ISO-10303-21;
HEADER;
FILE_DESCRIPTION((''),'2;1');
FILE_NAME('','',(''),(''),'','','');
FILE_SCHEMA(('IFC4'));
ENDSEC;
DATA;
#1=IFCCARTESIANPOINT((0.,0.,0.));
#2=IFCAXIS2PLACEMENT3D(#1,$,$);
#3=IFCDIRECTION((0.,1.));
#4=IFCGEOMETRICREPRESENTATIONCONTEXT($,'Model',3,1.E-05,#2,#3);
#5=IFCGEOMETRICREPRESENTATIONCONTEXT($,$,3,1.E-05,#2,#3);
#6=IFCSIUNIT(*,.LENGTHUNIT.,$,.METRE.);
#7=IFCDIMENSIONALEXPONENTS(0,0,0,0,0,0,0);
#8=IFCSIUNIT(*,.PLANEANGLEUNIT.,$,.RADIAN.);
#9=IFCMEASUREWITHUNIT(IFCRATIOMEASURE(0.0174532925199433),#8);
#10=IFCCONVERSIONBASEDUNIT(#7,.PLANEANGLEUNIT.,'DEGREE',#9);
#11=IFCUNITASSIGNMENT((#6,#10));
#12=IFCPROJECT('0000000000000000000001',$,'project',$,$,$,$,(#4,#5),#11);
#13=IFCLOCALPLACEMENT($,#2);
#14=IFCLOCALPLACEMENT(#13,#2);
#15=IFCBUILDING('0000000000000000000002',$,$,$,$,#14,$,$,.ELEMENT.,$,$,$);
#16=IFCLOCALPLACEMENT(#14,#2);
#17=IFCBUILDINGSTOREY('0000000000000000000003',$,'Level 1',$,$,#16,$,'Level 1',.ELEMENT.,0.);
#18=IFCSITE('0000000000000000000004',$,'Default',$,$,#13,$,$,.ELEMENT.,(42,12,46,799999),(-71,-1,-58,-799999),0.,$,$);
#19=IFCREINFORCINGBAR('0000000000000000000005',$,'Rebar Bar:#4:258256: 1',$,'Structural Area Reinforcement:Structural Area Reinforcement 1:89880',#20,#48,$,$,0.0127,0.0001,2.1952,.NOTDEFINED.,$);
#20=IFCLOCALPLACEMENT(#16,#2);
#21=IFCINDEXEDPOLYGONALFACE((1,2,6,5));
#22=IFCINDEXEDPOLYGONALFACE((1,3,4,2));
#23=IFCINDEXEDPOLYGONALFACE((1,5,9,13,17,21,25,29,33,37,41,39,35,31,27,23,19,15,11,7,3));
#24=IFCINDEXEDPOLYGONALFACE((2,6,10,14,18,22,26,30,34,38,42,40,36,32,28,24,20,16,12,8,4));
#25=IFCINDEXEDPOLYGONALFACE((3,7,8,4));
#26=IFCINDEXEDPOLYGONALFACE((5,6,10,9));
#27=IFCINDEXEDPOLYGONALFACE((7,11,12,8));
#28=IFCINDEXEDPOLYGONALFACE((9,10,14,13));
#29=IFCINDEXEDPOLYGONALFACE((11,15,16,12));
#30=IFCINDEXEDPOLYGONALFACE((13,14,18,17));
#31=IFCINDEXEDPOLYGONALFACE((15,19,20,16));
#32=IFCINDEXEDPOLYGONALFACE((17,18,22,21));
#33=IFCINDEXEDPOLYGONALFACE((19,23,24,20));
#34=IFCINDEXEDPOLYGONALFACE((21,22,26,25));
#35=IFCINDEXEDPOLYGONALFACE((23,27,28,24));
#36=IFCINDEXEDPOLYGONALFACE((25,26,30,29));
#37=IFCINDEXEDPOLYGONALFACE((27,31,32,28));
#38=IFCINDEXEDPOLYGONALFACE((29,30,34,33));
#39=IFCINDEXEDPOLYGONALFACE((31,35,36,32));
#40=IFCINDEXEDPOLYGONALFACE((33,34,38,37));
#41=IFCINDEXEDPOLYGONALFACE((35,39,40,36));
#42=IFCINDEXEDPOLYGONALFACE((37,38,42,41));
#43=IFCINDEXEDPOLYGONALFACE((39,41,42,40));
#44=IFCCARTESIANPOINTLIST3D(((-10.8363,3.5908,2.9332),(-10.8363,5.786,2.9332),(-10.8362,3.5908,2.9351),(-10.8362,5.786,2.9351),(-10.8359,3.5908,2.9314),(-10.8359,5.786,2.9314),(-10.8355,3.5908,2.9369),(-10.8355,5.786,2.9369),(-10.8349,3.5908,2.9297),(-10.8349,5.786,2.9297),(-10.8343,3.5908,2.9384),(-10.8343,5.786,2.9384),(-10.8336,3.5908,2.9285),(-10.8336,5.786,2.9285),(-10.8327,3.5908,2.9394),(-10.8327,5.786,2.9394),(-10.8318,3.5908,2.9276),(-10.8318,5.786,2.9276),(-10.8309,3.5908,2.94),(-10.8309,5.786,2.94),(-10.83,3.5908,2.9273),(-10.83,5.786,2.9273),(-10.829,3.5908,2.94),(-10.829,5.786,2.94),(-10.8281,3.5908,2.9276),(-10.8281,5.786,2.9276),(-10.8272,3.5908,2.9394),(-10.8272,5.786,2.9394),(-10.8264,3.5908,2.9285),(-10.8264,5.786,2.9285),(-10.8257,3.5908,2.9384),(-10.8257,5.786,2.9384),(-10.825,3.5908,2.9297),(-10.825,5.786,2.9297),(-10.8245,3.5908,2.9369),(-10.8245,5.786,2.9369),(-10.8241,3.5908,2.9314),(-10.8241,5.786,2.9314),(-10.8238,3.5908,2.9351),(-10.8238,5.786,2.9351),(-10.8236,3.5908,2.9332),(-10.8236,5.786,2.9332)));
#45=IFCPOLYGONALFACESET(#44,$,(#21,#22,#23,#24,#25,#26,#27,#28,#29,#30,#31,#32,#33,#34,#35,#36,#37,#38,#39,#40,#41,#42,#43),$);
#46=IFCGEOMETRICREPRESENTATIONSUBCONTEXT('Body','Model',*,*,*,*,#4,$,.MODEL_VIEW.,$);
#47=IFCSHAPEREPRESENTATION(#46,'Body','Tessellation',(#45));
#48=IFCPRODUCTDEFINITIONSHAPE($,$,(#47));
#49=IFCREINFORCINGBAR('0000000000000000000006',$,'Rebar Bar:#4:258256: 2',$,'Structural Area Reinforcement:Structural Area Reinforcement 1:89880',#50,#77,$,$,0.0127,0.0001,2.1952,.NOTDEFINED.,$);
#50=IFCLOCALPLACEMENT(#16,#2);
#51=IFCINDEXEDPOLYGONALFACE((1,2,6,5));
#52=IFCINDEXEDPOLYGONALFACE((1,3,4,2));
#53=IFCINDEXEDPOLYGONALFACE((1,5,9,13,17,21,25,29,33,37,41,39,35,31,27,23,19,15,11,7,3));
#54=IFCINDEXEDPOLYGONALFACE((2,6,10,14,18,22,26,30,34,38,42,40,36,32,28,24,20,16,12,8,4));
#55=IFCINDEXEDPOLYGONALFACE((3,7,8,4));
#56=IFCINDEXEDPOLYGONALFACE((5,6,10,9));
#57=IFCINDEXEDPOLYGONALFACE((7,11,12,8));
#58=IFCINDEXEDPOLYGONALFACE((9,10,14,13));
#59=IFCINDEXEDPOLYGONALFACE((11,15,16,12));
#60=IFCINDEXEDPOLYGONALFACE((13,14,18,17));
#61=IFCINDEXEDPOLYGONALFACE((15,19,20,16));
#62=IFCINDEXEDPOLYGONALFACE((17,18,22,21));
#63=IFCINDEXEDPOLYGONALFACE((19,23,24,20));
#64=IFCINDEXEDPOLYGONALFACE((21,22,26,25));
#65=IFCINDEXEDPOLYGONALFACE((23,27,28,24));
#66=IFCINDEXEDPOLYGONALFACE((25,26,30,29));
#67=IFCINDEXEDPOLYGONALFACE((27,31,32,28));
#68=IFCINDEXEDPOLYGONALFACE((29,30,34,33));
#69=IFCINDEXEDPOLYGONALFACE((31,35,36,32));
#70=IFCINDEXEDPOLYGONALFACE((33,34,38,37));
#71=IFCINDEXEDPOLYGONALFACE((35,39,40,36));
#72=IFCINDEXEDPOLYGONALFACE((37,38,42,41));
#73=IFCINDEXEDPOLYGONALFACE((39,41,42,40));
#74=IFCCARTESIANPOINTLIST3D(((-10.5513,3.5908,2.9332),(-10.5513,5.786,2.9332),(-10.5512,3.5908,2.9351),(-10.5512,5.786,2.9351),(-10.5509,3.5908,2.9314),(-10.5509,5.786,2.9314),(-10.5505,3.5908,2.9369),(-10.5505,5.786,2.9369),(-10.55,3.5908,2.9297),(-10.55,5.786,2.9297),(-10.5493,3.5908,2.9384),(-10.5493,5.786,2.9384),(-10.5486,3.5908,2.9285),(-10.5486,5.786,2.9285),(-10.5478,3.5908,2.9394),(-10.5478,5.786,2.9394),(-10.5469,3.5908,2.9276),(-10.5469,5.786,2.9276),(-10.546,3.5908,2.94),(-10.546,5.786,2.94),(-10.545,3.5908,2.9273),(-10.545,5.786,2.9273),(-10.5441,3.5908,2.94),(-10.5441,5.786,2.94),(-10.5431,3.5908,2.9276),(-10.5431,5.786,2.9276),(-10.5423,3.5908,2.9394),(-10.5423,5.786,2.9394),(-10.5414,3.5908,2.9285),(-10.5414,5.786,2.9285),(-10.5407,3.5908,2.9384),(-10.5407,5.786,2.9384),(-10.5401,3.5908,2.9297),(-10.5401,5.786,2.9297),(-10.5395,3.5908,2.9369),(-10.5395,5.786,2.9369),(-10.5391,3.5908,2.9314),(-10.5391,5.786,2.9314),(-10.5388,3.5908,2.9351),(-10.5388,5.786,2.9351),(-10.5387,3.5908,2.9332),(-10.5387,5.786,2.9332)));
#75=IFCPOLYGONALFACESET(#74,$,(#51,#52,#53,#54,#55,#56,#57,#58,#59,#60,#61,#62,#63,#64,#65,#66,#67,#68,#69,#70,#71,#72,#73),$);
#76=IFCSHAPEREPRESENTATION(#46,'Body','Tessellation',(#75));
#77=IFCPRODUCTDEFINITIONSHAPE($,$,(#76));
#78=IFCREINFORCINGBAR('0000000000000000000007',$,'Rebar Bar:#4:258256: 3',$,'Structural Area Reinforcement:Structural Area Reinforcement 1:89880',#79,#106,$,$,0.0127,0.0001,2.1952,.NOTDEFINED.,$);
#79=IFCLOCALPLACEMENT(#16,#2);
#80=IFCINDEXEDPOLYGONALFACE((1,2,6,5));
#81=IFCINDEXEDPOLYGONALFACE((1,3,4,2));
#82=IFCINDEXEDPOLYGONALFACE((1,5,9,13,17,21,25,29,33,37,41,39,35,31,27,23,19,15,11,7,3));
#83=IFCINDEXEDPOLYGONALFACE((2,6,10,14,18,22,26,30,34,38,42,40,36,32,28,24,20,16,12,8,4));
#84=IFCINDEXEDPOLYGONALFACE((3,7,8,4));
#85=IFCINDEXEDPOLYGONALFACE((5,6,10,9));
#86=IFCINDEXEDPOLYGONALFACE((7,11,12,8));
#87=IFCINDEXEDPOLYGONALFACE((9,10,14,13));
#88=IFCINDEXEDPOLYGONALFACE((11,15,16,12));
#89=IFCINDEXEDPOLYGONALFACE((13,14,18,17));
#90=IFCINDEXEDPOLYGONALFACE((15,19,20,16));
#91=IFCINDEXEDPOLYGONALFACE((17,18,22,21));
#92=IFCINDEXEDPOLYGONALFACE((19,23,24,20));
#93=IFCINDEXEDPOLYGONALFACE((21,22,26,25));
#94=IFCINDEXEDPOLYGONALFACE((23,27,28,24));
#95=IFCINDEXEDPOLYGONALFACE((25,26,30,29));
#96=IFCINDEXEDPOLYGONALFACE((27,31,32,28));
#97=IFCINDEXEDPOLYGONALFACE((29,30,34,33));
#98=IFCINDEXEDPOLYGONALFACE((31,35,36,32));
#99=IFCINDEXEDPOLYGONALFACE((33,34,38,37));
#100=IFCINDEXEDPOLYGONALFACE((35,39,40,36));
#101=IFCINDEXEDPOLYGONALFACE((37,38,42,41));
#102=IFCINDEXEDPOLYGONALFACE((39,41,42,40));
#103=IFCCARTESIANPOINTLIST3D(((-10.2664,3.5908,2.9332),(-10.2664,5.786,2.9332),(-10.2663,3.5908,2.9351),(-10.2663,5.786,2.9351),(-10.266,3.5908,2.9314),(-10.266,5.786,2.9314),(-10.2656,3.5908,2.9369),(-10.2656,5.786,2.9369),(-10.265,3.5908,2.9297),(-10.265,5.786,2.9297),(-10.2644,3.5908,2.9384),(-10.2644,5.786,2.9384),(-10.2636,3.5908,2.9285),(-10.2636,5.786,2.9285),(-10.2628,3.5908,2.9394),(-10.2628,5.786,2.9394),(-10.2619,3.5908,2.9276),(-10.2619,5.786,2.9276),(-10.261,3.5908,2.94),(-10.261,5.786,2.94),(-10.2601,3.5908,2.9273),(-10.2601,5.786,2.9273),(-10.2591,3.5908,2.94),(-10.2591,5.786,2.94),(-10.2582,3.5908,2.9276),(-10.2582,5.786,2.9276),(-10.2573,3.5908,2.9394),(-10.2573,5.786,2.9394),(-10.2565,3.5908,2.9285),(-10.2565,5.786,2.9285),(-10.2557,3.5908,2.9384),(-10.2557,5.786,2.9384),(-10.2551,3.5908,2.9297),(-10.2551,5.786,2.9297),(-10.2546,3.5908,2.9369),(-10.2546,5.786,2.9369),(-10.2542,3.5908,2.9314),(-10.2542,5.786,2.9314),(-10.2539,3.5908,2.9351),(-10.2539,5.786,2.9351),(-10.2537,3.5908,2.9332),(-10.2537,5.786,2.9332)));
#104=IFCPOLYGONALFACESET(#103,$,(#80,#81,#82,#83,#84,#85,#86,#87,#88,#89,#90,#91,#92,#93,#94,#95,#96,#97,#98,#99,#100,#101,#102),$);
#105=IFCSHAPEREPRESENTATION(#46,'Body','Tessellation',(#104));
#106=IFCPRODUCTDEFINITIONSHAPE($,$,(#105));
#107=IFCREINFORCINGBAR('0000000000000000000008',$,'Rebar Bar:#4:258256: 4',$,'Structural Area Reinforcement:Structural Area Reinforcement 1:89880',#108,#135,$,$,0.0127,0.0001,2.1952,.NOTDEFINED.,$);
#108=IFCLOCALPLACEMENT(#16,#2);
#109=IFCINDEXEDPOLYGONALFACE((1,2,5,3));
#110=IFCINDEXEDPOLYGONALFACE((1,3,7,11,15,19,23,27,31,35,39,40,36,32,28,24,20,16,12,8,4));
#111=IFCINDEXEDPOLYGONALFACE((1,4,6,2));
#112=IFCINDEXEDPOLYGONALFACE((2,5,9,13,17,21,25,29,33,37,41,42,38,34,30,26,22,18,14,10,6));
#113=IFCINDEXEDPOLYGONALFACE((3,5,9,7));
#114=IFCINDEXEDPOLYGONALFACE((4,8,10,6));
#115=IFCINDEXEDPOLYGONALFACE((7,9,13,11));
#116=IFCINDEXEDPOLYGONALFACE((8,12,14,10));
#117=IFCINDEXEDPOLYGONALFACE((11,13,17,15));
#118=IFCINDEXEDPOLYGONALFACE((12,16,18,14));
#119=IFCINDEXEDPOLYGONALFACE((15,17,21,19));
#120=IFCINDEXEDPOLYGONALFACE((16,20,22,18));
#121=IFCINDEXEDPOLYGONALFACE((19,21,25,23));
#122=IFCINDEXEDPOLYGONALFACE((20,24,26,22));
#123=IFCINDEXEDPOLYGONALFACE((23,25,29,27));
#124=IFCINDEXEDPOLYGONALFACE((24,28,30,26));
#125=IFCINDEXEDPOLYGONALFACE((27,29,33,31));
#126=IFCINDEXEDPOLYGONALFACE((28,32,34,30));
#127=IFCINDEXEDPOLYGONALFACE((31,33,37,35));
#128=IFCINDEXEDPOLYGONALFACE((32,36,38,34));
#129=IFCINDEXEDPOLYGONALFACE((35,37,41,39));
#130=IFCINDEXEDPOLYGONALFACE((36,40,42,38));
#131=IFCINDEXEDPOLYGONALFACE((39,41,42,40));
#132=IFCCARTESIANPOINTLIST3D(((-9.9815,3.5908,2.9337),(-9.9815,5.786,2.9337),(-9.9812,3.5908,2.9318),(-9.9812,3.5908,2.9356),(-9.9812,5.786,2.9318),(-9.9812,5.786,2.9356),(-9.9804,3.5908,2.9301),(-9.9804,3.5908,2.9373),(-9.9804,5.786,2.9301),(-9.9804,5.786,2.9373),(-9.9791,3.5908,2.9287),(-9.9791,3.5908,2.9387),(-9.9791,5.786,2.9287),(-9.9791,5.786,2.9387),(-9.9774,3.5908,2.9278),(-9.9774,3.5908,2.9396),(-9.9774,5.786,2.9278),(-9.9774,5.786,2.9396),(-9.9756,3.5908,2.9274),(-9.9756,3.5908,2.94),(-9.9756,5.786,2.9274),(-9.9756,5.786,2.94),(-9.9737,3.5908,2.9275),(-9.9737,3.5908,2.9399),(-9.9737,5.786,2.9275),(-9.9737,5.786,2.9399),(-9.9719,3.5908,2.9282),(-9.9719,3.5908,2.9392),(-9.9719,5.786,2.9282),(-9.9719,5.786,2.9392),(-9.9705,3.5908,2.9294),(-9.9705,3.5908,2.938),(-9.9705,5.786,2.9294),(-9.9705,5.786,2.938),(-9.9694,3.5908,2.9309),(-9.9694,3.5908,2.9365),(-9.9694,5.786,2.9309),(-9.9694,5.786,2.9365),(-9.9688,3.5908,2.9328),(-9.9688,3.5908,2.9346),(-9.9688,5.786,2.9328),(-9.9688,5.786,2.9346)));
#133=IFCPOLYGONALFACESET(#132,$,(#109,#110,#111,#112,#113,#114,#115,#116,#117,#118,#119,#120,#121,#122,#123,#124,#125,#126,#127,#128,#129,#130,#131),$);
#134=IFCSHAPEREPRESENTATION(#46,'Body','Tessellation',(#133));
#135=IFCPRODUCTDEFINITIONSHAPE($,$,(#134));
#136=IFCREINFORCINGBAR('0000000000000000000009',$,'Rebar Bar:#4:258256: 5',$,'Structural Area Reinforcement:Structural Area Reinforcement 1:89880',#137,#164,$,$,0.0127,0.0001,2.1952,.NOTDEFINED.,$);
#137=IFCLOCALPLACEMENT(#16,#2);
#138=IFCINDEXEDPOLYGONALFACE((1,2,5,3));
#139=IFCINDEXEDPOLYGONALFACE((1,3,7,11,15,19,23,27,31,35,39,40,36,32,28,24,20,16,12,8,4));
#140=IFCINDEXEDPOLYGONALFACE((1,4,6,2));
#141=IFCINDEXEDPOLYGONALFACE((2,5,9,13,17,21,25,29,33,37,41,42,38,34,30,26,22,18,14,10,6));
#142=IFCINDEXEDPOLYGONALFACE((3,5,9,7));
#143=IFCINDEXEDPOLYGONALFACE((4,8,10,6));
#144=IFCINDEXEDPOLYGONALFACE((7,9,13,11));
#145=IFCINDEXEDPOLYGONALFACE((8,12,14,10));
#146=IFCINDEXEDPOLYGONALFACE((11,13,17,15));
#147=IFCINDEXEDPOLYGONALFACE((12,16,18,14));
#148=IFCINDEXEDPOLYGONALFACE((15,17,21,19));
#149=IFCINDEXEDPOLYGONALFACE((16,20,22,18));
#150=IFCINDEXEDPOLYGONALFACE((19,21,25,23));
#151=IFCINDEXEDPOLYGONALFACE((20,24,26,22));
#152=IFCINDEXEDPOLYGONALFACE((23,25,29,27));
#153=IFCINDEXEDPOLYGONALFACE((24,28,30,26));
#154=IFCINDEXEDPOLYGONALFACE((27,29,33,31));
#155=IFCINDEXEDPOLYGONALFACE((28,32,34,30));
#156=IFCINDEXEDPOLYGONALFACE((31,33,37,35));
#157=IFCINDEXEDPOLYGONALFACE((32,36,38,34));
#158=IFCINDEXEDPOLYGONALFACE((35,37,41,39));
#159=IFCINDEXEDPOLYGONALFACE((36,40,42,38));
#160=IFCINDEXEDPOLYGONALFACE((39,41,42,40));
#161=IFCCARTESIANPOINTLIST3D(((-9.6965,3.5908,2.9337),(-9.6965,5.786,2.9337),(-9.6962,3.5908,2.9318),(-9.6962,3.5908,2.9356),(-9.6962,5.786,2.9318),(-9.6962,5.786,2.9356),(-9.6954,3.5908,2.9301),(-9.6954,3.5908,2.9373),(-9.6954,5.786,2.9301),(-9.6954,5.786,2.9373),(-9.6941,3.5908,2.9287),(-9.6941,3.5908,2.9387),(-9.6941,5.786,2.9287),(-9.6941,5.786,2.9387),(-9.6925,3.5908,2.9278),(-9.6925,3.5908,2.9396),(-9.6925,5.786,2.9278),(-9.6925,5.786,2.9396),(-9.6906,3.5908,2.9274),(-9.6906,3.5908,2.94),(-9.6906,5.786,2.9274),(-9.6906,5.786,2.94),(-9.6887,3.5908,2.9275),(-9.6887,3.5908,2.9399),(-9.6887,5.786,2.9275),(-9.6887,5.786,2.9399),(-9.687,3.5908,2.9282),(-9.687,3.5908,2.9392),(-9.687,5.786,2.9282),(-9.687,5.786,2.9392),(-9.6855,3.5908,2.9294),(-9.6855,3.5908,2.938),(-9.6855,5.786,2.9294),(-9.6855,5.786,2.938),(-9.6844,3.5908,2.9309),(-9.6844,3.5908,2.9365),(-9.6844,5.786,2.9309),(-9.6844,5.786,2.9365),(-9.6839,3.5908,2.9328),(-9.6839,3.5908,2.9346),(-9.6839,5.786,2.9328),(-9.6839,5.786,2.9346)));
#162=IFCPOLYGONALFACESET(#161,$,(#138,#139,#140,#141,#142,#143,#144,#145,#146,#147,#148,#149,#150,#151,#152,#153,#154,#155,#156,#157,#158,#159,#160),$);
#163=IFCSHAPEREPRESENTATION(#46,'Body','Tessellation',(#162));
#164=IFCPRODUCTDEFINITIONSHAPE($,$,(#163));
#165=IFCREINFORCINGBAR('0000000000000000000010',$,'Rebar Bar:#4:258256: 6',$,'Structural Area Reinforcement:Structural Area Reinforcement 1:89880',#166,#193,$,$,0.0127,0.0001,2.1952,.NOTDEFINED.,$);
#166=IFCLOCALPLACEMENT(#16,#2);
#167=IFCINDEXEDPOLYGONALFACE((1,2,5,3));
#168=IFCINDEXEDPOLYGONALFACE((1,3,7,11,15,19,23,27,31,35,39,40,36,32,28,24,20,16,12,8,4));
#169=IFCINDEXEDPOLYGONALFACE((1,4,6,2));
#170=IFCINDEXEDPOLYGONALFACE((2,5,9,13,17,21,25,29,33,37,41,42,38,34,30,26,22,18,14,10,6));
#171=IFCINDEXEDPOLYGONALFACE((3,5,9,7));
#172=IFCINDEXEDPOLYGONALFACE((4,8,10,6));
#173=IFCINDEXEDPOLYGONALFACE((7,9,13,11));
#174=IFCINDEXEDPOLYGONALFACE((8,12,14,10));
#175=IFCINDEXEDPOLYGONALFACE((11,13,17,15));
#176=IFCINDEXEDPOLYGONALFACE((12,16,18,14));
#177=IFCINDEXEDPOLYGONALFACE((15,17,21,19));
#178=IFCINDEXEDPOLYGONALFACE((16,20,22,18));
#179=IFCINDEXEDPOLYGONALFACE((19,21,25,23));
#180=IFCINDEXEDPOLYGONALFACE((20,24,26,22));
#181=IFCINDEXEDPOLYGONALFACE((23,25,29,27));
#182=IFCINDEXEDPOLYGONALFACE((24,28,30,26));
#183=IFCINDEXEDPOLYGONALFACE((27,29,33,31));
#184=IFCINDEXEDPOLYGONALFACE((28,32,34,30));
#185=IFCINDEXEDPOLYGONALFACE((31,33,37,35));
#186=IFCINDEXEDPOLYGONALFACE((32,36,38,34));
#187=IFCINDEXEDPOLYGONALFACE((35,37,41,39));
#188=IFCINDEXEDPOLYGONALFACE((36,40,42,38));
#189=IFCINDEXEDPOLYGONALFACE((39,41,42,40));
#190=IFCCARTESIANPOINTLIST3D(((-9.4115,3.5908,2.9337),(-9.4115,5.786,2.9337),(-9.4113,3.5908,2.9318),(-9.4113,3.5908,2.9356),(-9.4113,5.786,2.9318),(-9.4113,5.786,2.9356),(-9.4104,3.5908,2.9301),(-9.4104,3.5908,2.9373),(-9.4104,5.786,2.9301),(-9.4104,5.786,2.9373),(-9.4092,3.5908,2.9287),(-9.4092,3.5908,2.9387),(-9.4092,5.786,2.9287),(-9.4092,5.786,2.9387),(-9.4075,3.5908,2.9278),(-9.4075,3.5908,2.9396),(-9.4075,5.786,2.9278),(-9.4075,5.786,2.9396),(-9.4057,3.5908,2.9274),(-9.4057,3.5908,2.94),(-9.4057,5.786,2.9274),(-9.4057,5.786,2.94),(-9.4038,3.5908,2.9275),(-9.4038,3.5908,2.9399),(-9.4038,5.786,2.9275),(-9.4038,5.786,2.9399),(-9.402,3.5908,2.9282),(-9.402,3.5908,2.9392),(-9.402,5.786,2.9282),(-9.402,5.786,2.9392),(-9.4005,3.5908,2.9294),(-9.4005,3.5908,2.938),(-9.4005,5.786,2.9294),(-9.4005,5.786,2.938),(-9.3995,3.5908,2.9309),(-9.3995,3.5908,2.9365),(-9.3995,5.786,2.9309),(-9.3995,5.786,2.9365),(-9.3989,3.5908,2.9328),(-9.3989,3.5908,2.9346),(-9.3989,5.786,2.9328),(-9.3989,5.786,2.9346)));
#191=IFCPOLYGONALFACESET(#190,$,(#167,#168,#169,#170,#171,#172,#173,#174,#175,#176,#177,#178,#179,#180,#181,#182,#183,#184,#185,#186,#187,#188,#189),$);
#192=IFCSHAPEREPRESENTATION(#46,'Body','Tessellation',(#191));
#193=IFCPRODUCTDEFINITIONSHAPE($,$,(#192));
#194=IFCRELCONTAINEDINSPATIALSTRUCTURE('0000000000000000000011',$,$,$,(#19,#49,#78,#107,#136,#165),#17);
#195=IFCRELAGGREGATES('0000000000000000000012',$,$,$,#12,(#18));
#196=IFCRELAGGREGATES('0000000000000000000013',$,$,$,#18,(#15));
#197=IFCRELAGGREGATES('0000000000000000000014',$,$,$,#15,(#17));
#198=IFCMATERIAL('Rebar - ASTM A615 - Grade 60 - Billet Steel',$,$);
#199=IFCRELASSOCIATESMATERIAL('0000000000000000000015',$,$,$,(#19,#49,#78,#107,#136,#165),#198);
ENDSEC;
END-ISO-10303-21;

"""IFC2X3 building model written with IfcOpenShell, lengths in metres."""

from ifc_helpers import new_model, entity, si_unit, converted_unit, direction, origin, place, context, subcontext, project, spatial, material, element, save


model = new_model("IFC2X3")

# Units and contexts
model_context = context("Model", 3, precision=1e-05, world=origin(), true_north=direction((0.0, 1.0)))
context_of_model = context(None, 3, precision=1e-05, world=origin(), true_north=direction((0.0, 1.0)))
body_context = subcontext(model_context, "Body", "Model", "MODEL_VIEW")
ifc_project = project(units=[si_unit("LENGTHUNIT", "METRE"), converted_unit("PLANEANGLEUNIT", "DEGREE", entity("IfcRatioMeasure", 0.0174532925199433), si_unit("PLANEANGLEUNIT", "RADIAN"), dimensions=[0, 0, 0, 0, 0, 0, 0])], contexts=[model_context, context_of_model])

# Site, building, storey
site_placement = place(None, origin())
site = spatial("IfcSite", under=ifc_project, at=site_placement, Name="Default", CompositionType="ELEMENT", RefLatitude=(42, 12, 46, 799999), RefLongitude=(-71, -1, -58, -799999), RefElevation=0.0)
building_placement = place(site_placement, origin())
building = spatial("IfcBuilding", under=site, at=building_placement, CompositionType="ELEMENT")
storey_placement = place(building_placement, origin())
storey = spatial("IfcBuildingStorey", under=building, at=storey_placement, Name="Level 1", LongName="Level 1", CompositionType="ELEMENT", Elevation=0.0)

# Shared definitions
ifc_material_1 = material(Name="Rebar - ASTM A615 - Grade 60 - Billet Steel")

# Reinforcing bars
reinforcing_bar_1_placement = place(storey_placement, origin())
element("IfcReinforcingBar", 1, at=reinforcing_bar_1_placement, inside=storey, material=ifc_material_1, Name="Rebar Bar:#4:258256: 1", ObjectType="Structural Area Reinforcement:Structural Area Reinforcement 1:89880", BarLength=2.1952, BarRole="NOTDEFINED", CrossSectionArea=0.0001, NominalDiameter=0.0127, context=body_context, shape_type="AdvancedSweptSolid", body=[
    entity("IfcSweptDiskSolid", entity("IfcCompositeCurve", [entity("IfcCompositeCurveSegment", "CONTINUOUS", True, entity("IfcPolyline", [entity("IfcCartesianPoint", [-10.83, 5.786, 2.9337]), entity("IfcCartesianPoint", [-10.83, 3.5908, 2.9337])]))], False), 0.0063, None, 0.0, 1.0),
])
reinforcing_bar_2_placement = place(storey_placement, origin())
element("IfcReinforcingBar", 2, at=reinforcing_bar_2_placement, inside=storey, material=ifc_material_1, Name="Rebar Bar:#4:258256: 2", ObjectType="Structural Area Reinforcement:Structural Area Reinforcement 1:89880", BarLength=2.1952, BarRole="NOTDEFINED", CrossSectionArea=0.0001, NominalDiameter=0.0127, context=body_context, shape_type="AdvancedSweptSolid", body=[
    entity("IfcSweptDiskSolid", entity("IfcCompositeCurve", [entity("IfcCompositeCurveSegment", "CONTINUOUS", True, entity("IfcPolyline", [entity("IfcCartesianPoint", [-10.545, 5.786, 2.9337]), entity("IfcCartesianPoint", [-10.545, 3.5908, 2.9337])]))], False), 0.0063, None, 0.0, 1.0),
])
reinforcing_bar_3_placement = place(storey_placement, origin())
element("IfcReinforcingBar", 3, at=reinforcing_bar_3_placement, inside=storey, material=ifc_material_1, Name="Rebar Bar:#4:258256: 3", ObjectType="Structural Area Reinforcement:Structural Area Reinforcement 1:89880", BarLength=2.1952, BarRole="NOTDEFINED", CrossSectionArea=0.0001, NominalDiameter=0.0127, context=body_context, shape_type="AdvancedSweptSolid", body=[
    entity("IfcSweptDiskSolid", entity("IfcCompositeCurve", [entity("IfcCompositeCurveSegment", "CONTINUOUS", True, entity("IfcPolyline", [entity("IfcCartesianPoint", [-10.2601, 5.786, 2.9337]), entity("IfcCartesianPoint", [-10.2601, 3.5908, 2.9337])]))], False), 0.0063, None, 0.0, 1.0),
])
reinforcing_bar_4_placement = place(storey_placement, origin())
element("IfcReinforcingBar", 4, at=reinforcing_bar_4_placement, inside=storey, material=ifc_material_1, Name="Rebar Bar:#4:258256: 4", ObjectType="Structural Area Reinforcement:Structural Area Reinforcement 1:89880", BarLength=2.1952, BarRole="NOTDEFINED", CrossSectionArea=0.0001, NominalDiameter=0.0127, context=body_context, shape_type="AdvancedSweptSolid", body=[
    entity("IfcSweptDiskSolid", entity("IfcCompositeCurve", [entity("IfcCompositeCurveSegment", "CONTINUOUS", True, entity("IfcPolyline", [entity("IfcCartesianPoint", [-9.9751, 5.786, 2.9337]), entity("IfcCartesianPoint", [-9.9751, 3.5908, 2.9337])]))], False), 0.0063, None, 0.0, 1.0),
])
reinforcing_bar_5_placement = place(storey_placement, origin())
element("IfcReinforcingBar", 5, at=reinforcing_bar_5_placement, inside=storey, material=ifc_material_1, Name="Rebar Bar:#4:258256: 5", ObjectType="Structural Area Reinforcement:Structural Area Reinforcement 1:89880", BarLength=2.1952, BarRole="NOTDEFINED", CrossSectionArea=0.0001, NominalDiameter=0.0127, context=body_context, shape_type="AdvancedSweptSolid", body=[
    entity("IfcSweptDiskSolid", entity("IfcCompositeCurve", [entity("IfcCompositeCurveSegment", "CONTINUOUS", True, entity("IfcPolyline", [entity("IfcCartesianPoint", [-9.6901, 5.786, 2.9337]), entity("IfcCartesianPoint", [-9.6901, 3.5908, 2.9337])]))], False), 0.0063, None, 0.0, 1.0),
])
reinforcing_bar_6_placement = place(storey_placement, origin())
element("IfcReinforcingBar", 6, at=reinforcing_bar_6_placement, inside=storey, material=ifc_material_1, Name="Rebar Bar:#4:258256: 6", ObjectType="Structural Area Reinforcement:Structural Area Reinforcement 1:89880", BarLength=2.1952, BarRole="NOTDEFINED", CrossSectionArea=0.0001, NominalDiameter=0.0127, context=body_context, shape_type="AdvancedSweptSolid", body=[
    entity("IfcSweptDiskSolid", entity("IfcCompositeCurve", [entity("IfcCompositeCurveSegment", "CONTINUOUS", True, entity("IfcPolyline", [entity("IfcCartesianPoint", [-9.4052, 5.786, 2.9337]), entity("IfcCartesianPoint", [-9.4052, 3.5908, 2.9337])]))], False), 0.0063, None, 0.0, 1.0),
])

save(model, "model.ifc")
